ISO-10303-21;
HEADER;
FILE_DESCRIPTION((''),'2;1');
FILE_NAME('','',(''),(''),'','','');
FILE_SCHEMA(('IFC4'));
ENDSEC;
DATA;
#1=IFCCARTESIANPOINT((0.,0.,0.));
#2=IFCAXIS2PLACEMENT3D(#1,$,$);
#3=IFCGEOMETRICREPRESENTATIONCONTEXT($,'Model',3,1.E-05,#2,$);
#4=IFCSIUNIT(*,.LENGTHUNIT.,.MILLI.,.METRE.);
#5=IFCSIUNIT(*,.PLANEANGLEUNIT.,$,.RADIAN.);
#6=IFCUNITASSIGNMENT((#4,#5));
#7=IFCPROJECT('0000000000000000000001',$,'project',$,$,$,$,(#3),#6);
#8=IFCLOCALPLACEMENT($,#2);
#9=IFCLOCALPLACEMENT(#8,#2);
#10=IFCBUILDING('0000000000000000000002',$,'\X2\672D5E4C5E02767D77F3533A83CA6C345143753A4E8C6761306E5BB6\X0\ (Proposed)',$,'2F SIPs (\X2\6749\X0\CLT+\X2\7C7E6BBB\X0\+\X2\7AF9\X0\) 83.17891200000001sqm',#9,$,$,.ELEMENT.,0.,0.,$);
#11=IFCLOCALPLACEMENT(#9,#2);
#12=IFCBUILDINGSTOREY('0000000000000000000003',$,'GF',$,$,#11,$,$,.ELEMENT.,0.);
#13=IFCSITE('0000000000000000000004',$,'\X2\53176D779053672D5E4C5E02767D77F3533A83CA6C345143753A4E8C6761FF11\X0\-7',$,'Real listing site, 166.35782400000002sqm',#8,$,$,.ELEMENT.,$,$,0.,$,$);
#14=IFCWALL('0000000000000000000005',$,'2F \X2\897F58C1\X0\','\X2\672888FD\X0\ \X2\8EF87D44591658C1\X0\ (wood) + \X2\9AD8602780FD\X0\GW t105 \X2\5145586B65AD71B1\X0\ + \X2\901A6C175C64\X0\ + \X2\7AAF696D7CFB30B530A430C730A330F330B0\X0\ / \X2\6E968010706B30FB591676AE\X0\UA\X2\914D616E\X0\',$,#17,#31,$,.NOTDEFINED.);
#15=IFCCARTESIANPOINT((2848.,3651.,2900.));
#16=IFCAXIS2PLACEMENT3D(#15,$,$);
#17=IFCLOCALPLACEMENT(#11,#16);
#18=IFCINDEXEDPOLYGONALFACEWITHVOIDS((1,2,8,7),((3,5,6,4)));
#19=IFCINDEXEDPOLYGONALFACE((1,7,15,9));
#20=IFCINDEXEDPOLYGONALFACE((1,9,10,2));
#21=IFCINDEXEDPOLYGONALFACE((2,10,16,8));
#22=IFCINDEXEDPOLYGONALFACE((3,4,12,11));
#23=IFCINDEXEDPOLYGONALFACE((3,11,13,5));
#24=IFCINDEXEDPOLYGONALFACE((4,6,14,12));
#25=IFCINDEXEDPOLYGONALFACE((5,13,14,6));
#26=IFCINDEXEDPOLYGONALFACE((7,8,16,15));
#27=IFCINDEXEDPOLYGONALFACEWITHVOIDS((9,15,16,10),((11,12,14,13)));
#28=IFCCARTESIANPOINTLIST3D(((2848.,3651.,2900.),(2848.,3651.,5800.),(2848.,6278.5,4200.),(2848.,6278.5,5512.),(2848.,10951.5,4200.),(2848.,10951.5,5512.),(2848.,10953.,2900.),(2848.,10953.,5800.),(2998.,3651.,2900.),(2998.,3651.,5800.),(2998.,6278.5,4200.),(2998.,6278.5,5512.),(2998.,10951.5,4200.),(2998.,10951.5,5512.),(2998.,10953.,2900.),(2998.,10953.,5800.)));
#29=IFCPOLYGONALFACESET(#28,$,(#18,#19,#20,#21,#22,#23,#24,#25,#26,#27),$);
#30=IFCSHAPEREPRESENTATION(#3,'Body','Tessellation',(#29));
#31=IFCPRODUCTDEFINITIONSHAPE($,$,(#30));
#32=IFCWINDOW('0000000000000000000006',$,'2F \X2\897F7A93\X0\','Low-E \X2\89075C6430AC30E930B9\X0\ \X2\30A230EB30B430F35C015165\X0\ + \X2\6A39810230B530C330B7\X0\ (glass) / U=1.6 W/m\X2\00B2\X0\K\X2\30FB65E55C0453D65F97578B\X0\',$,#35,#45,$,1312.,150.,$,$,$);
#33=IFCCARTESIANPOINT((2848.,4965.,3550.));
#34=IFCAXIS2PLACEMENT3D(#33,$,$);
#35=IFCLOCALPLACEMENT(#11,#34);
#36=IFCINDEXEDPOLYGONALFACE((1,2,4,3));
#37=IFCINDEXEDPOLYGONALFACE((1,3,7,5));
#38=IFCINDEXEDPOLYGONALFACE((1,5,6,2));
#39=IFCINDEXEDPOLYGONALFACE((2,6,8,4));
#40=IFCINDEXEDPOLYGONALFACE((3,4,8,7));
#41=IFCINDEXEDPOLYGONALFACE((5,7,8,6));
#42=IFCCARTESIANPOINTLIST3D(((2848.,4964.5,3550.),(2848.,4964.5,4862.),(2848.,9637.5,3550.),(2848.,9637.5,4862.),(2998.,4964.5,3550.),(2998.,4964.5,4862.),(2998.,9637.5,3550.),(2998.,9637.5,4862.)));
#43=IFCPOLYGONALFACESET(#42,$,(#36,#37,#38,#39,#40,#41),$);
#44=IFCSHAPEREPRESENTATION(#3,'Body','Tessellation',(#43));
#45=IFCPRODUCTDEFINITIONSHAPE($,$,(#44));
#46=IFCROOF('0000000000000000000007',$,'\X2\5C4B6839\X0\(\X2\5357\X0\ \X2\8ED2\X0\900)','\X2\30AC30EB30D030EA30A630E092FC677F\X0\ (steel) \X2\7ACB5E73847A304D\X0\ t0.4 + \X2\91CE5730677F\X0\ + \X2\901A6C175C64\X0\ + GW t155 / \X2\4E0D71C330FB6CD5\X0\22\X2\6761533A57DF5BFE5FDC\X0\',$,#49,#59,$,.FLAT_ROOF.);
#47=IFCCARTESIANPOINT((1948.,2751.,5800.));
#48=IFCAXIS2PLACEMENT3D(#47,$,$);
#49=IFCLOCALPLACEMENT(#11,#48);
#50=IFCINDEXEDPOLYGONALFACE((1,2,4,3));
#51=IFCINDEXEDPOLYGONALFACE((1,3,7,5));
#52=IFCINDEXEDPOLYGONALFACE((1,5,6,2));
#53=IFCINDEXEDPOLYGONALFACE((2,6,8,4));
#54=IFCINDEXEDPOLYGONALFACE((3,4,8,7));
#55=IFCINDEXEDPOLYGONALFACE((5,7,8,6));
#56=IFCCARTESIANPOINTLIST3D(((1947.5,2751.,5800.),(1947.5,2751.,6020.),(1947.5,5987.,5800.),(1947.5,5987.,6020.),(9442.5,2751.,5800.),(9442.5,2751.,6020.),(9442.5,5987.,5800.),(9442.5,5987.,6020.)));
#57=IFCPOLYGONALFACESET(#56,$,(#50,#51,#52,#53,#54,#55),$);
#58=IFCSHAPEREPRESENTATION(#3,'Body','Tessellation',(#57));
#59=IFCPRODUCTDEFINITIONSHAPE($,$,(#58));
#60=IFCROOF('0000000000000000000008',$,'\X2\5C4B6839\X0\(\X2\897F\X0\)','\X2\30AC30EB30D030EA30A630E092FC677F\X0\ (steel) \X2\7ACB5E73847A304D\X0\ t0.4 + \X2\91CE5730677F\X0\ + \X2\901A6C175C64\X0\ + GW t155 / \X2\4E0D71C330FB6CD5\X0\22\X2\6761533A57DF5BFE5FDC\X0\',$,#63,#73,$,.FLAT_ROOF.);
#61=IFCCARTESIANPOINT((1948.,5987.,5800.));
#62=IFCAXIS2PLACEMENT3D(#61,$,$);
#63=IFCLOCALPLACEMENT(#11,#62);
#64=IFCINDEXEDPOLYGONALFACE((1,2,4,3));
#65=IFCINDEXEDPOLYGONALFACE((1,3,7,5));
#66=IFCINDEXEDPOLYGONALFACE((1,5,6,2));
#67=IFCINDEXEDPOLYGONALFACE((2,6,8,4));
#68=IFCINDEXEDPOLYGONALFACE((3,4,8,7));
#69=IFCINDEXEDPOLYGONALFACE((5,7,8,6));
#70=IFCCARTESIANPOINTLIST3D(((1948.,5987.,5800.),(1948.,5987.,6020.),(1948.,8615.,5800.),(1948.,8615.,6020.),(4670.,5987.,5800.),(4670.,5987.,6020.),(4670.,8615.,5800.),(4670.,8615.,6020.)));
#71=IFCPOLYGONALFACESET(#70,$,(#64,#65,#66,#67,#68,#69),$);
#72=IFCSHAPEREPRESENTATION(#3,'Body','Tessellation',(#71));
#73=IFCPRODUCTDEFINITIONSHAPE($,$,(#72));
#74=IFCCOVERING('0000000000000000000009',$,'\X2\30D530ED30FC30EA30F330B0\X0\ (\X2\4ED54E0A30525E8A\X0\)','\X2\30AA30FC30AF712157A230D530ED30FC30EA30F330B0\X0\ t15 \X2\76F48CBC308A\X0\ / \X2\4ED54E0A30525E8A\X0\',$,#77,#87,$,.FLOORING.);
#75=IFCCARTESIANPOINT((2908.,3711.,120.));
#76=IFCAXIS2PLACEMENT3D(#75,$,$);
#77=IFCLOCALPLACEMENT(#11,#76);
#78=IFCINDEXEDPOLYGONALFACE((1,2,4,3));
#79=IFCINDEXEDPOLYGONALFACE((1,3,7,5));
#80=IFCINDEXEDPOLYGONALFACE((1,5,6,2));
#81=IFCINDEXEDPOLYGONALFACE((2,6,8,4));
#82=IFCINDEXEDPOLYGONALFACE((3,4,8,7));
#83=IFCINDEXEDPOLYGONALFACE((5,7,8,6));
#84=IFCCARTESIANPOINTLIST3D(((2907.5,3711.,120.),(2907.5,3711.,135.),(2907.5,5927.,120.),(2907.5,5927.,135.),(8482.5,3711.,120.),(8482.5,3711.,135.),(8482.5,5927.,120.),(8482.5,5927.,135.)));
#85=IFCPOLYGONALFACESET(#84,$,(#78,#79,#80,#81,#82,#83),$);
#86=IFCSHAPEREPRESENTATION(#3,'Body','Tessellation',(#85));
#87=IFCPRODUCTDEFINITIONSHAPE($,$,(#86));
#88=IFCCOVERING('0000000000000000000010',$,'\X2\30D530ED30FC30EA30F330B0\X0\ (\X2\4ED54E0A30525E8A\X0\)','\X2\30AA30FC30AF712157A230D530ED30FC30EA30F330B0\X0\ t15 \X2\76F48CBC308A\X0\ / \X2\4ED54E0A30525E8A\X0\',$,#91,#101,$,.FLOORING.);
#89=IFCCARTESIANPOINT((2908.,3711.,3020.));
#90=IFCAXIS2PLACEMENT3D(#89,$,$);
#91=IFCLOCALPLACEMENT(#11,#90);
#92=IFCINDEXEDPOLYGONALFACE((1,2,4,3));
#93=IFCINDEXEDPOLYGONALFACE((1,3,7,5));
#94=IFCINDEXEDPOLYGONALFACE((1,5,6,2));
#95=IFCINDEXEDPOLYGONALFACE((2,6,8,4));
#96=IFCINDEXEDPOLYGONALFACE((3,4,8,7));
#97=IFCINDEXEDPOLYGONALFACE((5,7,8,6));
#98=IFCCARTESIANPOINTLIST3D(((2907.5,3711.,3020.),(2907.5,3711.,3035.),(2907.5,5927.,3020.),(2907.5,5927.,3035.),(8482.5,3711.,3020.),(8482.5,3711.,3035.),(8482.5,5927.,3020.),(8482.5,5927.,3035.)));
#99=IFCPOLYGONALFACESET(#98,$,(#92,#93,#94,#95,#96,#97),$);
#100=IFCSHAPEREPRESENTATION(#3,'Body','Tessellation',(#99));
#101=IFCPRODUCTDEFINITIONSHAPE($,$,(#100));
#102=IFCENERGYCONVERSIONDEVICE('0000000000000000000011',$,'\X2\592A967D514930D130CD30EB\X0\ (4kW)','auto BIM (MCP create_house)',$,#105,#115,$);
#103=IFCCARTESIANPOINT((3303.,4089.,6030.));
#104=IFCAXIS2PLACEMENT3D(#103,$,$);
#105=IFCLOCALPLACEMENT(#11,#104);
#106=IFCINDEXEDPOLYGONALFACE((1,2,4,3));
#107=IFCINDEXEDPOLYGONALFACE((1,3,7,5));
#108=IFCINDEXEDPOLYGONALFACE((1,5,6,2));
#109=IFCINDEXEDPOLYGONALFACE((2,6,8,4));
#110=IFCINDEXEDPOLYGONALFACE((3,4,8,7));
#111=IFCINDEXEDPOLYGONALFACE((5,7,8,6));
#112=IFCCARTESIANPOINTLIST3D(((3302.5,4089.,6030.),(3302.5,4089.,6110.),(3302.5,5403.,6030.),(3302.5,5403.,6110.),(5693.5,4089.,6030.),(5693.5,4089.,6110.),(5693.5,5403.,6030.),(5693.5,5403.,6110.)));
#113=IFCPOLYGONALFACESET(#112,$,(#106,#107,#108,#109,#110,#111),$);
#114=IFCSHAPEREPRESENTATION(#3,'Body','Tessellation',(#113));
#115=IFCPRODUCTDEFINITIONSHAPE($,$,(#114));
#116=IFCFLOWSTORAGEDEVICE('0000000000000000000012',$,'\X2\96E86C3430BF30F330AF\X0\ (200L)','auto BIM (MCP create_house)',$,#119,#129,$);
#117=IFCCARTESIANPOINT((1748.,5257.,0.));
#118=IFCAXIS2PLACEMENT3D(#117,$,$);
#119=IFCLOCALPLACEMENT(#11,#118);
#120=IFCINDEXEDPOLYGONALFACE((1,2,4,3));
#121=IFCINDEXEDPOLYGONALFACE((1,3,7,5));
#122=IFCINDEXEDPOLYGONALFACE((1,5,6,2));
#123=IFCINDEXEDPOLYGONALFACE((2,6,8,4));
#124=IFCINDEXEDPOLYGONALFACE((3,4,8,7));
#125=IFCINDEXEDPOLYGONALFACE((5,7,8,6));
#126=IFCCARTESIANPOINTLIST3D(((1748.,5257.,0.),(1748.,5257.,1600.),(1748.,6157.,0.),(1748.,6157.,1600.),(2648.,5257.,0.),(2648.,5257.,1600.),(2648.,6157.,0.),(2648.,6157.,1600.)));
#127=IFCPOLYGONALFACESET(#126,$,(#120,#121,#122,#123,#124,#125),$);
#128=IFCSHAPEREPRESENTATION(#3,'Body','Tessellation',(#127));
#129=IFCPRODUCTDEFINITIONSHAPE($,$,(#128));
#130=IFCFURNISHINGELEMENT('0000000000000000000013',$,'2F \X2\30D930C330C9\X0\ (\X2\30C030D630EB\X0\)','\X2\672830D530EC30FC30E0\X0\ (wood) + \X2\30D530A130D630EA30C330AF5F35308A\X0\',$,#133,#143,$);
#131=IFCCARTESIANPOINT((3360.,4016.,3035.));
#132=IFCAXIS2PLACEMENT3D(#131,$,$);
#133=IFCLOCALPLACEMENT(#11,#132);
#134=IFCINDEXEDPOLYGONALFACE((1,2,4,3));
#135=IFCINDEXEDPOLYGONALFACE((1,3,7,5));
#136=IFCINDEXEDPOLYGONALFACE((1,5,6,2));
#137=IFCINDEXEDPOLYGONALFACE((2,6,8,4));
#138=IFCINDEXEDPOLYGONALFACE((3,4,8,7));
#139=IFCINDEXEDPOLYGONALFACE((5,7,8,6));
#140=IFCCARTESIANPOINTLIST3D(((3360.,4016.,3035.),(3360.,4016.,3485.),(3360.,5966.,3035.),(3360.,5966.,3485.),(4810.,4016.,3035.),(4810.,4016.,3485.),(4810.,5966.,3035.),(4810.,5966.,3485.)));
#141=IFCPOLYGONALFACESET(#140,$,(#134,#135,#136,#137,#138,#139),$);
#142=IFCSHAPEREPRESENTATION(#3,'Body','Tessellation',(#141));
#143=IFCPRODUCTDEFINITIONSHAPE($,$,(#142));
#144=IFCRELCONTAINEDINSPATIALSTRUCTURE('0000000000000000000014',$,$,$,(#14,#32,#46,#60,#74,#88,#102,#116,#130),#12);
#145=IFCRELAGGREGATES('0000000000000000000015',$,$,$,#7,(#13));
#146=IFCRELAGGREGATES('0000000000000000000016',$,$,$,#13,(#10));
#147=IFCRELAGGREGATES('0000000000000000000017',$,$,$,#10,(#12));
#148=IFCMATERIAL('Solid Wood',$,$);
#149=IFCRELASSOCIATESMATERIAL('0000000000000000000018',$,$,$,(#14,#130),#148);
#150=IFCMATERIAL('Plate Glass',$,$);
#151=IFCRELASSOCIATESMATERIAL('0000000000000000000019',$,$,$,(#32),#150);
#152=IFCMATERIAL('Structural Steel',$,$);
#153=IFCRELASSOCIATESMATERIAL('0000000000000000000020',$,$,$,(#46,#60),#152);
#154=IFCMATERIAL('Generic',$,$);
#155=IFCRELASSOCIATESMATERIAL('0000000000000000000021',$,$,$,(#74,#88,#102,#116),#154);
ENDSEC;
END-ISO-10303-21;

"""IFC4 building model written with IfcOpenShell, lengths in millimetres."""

from ifc_helpers import new_model, si_unit, frame, frame_2d, origin, place, context, project, spatial, rectangle, extrude, material, element, fill, save


model = new_model("IFC4")

# Units and contexts
model_context = context("Model", 3, precision=1e-05, world=origin())
ifc_project = project(units=[si_unit("LENGTHUNIT", "METRE", prefix="MILLI"), si_unit("PLANEANGLEUNIT", "RADIAN")], contexts=[model_context])

# Site, building, storey
site_placement = place(None, origin())
site = spatial("IfcSite", under=ifc_project, at=site_placement, Name="北海道札幌市白石区菊水元町二条１-7", ObjectType="Real listing site, 166.35782400000002sqm", CompositionType="ELEMENT", RefElevation=0.0)
building_placement = place(site_placement, origin())
building = spatial("IfcBuilding", under=site, at=building_placement, Name="札幌市白石区菊水元町二条の家 (Proposed)", ObjectType="2F SIPs (杉CLT+籾殻+竹) 83.17891200000001sqm", CompositionType="ELEMENT", ElevationOfRefHeight=0.0, ElevationOfTerrain=0.0)
storey_placement = place(building_placement, origin())
storey = spatial("IfcBuildingStorey", under=building, at=storey_placement, Name="GF", CompositionType="ELEMENT", Elevation=0.0)

# Shared definitions
ifc_material_1 = material(Name="Solid Wood")

# Shared definitions
ifc_material_2 = material(Name="Plate Glass")

# Wall, opening, window
wall_1_placement = place(storey_placement, frame((2848.0, 3651.0, 2900.0)))
wall_1 = element("IfcWall", 1, at=wall_1_placement, inside=storey, material=ifc_material_1, Name="2F 西壁", Description="木製 軸組外壁 (wood) + 高性能GW t105 充填断熱 + 通気層 + 窯業系サイディング / 準耐火・外皮UA配慮", PredefinedType="NOTDEFINED", context=model_context, shape_type="SweptSolid", body=[
    extrude(rectangle(XDim=150.0, YDim=7302.0, at=frame_2d((75.0, 3651.0))), frame((2848.0, 3651.0, 2900.0)), (0.0, 0.0, 1.0), 2900.0),
])
opening_1_placement = place(storey_placement, frame((2848.0, 4965.0, 3550.0)))
opening_1 = element("IfcOpeningElement", 2, at=opening_1_placement, cuts=wall_1, PredefinedType="NOTDEFINED", context=model_context, shape_type="SweptSolid", body=[
    extrude(rectangle(XDim=150.0, YDim=4673.0, at=frame_2d((75.0, 2336.0))), frame((2848.0, 4965.0, 3550.0)), (0.0, 0.0, 1.0), 1312.0),
])
window_1_placement = place(storey_placement, frame((2848.0, 4965.0, 3550.0)))
window_1 = element("IfcWindow", 3, at=window_1_placement, inside=storey, material=ifc_material_2, Name="2F 西窓", Description="Low-E 複層ガラス アルゴン封入 + 樹脂サッシ (glass) / U=1.6 W/m²K・日射取得型", OverallHeight=1312.0, OverallWidth=150.0, context=model_context, shape_type="SweptSolid", body=[
    extrude(rectangle(XDim=150.0, YDim=4673.0, at=frame_2d((75.0, 2336.0))), frame((2848.0, 4965.0, 3550.0)), (0.0, 0.0, 1.0), 1312.0),
])
fill(opening_1, window_1)

# Roofs
ifc_material_3 = material(Name="Structural Steel")
roof_1_placement = place(storey_placement, frame((1948.0, 2751.0, 5800.0)))
element("IfcRoof", 4, at=roof_1_placement, inside=storey, material=ifc_material_3, Name="屋根(南 軒900)", Description="ガルバリウム鋼板 (steel) 立平葺き t0.4 + 野地板 + 通気層 + GW t155 / 不燃・法22条区域対応", PredefinedType="FLAT_ROOF", context=model_context, shape_type="SweptSolid", body=[
    extrude(rectangle(XDim=7495.0, YDim=3236.0, at=frame_2d((3747.0, 1618.0))), frame((1948.0, 2751.0, 5800.0)), (0.0, 0.0, 1.0), 220.0),
])
roof_2_placement = place(storey_placement, frame((1948.0, 5987.0, 5800.0)))
element("IfcRoof", 5, at=roof_2_placement, inside=storey, material=ifc_material_3, Name="屋根(西)", Description="ガルバリウム鋼板 (steel) 立平葺き t0.4 + 野地板 + 通気層 + GW t155 / 不燃・法22条区域対応", PredefinedType="FLAT_ROOF", context=model_context, shape_type="SweptSolid", body=[
    extrude(rectangle(XDim=2722.0, YDim=2628.0, at=frame_2d((1361.0, 1314.0))), frame((1948.0, 5987.0, 5800.0)), (0.0, 0.0, 1.0), 220.0),
])

# Coverings
ifc_material_4 = material(Name="Generic")
covering_1_placement = place(storey_placement, frame((2908.0, 3711.0, 120.0)))
element("IfcCovering", 6, at=covering_1_placement, inside=storey, material=ifc_material_4, Name="フローリング (仕上げ床)", Description="オーク無垢フローリング t15 直貼り / 仕上げ床", PredefinedType="FLOORING", context=model_context, shape_type="SweptSolid", body=[
    extrude(rectangle(XDim=5575.0, YDim=2216.0, at=frame_2d((2787.0, 1108.0))), frame((2908.0, 3711.0, 120.0)), (0.0, 0.0, 1.0), 15.0),
])
covering_2_placement = place(storey_placement, frame((2908.0, 3711.0, 3020.0)))
element("IfcCovering", 7, at=covering_2_placement, inside=storey, material=ifc_material_4, Name="フローリング (仕上げ床)", Description="オーク無垢フローリング t15 直貼り / 仕上げ床", PredefinedType="FLOORING", context=model_context, shape_type="SweptSolid", body=[
    extrude(rectangle(XDim=5575.0, YDim=2216.0, at=frame_2d((2787.0, 1108.0))), frame((2908.0, 3711.0, 3020.0)), (0.0, 0.0, 1.0), 15.0),
])

# Energy conversion device
energy_conversion_device_placement = place(storey_placement, frame((3303.0, 4089.0, 6030.0)))
element("IfcEnergyConversionDevice", 8, at=energy_conversion_device_placement, inside=storey, material=ifc_material_4, Name="太陽光パネル (4kW)", Description="auto BIM (MCP create_house)", context=model_context, shape_type="SweptSolid", body=[
    extrude(rectangle(XDim=2391.0, YDim=1314.0, at=frame_2d((1195.0, 657.0))), frame((3303.0, 4089.0, 6030.0)), (0.0, 0.0, 1.0), 80.0),
])

# Flow storage device
flow_storage_device_placement = place(storey_placement, frame((1748.0, 5257.0, 0.0)))
element("IfcFlowStorageDevice", 9, at=flow_storage_device_placement, inside=storey, material=ifc_material_4, Name="雨水タンク (200L)", Description="auto BIM (MCP create_house)", context=model_context, shape_type="SweptSolid", body=[
    extrude(rectangle(XDim=900.0, YDim=900.0, at=frame_2d((450.0, 450.0))), frame((1748.0, 5257.0, 0.0)), (0.0, 0.0, 1.0), 1600.0),
])

# Furnishing element
furnishing_placement = place(storey_placement, frame((3360.0, 4016.0, 3035.0)))
element("IfcFurnishingElement", 10, at=furnishing_placement, inside=storey, material=ifc_material_1, Name="2F ベッド (ダブル)", Description="木フレーム (wood) + ファブリック張り", context=model_context, shape_type="SweptSolid", body=[
    extrude(rectangle(XDim=1450.0, YDim=1950.0, at=frame_2d((725.0, 975.0))), frame((3360.0, 4016.0, 3035.0)), (0.0, 0.0, 1.0), 450.0),
])

save(model, "model.ifc")
